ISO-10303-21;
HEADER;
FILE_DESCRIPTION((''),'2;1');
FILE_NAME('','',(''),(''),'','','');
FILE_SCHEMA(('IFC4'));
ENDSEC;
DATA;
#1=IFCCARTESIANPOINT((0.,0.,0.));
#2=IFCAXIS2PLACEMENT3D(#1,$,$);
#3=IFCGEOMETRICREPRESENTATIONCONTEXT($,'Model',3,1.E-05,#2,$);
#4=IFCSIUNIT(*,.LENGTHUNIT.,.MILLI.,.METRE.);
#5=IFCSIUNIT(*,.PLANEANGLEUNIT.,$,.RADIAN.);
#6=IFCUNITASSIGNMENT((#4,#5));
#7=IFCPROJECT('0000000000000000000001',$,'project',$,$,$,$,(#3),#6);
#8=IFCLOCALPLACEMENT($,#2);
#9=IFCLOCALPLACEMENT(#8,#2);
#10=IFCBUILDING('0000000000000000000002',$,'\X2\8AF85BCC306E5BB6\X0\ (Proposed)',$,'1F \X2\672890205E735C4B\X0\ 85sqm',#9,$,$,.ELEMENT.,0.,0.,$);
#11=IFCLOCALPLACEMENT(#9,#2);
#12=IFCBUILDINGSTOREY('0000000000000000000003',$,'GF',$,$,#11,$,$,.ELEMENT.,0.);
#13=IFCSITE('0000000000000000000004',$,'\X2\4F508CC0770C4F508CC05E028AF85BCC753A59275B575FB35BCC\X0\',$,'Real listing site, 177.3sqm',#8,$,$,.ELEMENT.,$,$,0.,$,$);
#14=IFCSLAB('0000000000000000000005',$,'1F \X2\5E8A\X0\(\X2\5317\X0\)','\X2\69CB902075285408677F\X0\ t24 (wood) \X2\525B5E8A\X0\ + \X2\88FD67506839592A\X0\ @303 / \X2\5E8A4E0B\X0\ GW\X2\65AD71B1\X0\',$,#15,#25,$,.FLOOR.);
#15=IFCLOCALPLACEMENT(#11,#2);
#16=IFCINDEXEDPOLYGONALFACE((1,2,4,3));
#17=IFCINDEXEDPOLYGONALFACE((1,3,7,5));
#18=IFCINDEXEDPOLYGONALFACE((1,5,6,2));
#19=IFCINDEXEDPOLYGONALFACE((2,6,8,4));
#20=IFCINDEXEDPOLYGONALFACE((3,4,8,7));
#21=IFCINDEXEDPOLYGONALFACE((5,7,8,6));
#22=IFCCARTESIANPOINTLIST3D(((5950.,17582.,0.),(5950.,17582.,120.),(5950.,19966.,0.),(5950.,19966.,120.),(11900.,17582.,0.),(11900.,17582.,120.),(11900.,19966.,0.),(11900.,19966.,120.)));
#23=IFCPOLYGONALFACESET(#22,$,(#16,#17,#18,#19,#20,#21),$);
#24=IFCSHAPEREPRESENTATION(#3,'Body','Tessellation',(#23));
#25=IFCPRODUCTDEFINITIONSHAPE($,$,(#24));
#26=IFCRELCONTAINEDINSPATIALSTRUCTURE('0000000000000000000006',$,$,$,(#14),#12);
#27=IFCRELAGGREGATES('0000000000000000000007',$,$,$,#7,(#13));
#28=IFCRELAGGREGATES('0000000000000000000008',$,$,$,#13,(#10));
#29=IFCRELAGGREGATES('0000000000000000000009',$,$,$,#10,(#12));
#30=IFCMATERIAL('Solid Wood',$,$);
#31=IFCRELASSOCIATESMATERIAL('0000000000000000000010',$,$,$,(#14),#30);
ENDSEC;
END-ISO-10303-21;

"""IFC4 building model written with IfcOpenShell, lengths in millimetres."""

from ifc_helpers import new_model, si_unit, frame, frame_2d, origin, place, context, project, spatial, rectangle, extrude, material, element, save


model = new_model("IFC4")

# Units and contexts
model_context = context("Model", 3, precision=1e-05, world=origin())
ifc_project = project(units=[si_unit("LENGTHUNIT", "METRE", prefix="MILLI"), si_unit("PLANEANGLEUNIT", "RADIAN")], contexts=[model_context])

# Site, building, storey
site_placement = place(None, origin())
site = spatial("IfcSite", under=ifc_project, at=site_placement, Name="佐賀県佐賀市諸富町大字徳富", ObjectType="Real listing site, 177.3sqm", CompositionType="ELEMENT", RefElevation=0.0)
building_placement = place(site_placement, origin())
building = spatial("IfcBuilding", under=site, at=building_placement, Name="諸富の家 (Proposed)", ObjectType="1F 木造平屋 85sqm", CompositionType="ELEMENT", ElevationOfRefHeight=0.0, ElevationOfTerrain=0.0)
storey_placement = place(building_placement, origin())
storey = spatial("IfcBuildingStorey", under=building, at=storey_placement, Name="GF", CompositionType="ELEMENT", Elevation=0.0)

# Slab
ifc_material_1 = material(Name="Solid Wood")
slab_1_placement = place(storey_placement, frame((2975.0, 8791.0, 0.0)))
element("IfcSlab", 1, at=slab_1_placement, inside=storey, material=ifc_material_1, Name="1F 床(北)", Description="構造用合板 t24 (wood) 剛床 + 製材根太 @303 / 床下 GW断熱", PredefinedType="FLOOR", context=model_context, shape_type="SweptSolid", body=[
    extrude(rectangle(XDim=5950.0, YDim=2384.0, at=frame_2d((2975.0, 1192.0))), frame((2975.0, 8791.0, 0.0)), (0.0, 0.0, 1.0), 120.0),
])

save(model, "model.ifc")
